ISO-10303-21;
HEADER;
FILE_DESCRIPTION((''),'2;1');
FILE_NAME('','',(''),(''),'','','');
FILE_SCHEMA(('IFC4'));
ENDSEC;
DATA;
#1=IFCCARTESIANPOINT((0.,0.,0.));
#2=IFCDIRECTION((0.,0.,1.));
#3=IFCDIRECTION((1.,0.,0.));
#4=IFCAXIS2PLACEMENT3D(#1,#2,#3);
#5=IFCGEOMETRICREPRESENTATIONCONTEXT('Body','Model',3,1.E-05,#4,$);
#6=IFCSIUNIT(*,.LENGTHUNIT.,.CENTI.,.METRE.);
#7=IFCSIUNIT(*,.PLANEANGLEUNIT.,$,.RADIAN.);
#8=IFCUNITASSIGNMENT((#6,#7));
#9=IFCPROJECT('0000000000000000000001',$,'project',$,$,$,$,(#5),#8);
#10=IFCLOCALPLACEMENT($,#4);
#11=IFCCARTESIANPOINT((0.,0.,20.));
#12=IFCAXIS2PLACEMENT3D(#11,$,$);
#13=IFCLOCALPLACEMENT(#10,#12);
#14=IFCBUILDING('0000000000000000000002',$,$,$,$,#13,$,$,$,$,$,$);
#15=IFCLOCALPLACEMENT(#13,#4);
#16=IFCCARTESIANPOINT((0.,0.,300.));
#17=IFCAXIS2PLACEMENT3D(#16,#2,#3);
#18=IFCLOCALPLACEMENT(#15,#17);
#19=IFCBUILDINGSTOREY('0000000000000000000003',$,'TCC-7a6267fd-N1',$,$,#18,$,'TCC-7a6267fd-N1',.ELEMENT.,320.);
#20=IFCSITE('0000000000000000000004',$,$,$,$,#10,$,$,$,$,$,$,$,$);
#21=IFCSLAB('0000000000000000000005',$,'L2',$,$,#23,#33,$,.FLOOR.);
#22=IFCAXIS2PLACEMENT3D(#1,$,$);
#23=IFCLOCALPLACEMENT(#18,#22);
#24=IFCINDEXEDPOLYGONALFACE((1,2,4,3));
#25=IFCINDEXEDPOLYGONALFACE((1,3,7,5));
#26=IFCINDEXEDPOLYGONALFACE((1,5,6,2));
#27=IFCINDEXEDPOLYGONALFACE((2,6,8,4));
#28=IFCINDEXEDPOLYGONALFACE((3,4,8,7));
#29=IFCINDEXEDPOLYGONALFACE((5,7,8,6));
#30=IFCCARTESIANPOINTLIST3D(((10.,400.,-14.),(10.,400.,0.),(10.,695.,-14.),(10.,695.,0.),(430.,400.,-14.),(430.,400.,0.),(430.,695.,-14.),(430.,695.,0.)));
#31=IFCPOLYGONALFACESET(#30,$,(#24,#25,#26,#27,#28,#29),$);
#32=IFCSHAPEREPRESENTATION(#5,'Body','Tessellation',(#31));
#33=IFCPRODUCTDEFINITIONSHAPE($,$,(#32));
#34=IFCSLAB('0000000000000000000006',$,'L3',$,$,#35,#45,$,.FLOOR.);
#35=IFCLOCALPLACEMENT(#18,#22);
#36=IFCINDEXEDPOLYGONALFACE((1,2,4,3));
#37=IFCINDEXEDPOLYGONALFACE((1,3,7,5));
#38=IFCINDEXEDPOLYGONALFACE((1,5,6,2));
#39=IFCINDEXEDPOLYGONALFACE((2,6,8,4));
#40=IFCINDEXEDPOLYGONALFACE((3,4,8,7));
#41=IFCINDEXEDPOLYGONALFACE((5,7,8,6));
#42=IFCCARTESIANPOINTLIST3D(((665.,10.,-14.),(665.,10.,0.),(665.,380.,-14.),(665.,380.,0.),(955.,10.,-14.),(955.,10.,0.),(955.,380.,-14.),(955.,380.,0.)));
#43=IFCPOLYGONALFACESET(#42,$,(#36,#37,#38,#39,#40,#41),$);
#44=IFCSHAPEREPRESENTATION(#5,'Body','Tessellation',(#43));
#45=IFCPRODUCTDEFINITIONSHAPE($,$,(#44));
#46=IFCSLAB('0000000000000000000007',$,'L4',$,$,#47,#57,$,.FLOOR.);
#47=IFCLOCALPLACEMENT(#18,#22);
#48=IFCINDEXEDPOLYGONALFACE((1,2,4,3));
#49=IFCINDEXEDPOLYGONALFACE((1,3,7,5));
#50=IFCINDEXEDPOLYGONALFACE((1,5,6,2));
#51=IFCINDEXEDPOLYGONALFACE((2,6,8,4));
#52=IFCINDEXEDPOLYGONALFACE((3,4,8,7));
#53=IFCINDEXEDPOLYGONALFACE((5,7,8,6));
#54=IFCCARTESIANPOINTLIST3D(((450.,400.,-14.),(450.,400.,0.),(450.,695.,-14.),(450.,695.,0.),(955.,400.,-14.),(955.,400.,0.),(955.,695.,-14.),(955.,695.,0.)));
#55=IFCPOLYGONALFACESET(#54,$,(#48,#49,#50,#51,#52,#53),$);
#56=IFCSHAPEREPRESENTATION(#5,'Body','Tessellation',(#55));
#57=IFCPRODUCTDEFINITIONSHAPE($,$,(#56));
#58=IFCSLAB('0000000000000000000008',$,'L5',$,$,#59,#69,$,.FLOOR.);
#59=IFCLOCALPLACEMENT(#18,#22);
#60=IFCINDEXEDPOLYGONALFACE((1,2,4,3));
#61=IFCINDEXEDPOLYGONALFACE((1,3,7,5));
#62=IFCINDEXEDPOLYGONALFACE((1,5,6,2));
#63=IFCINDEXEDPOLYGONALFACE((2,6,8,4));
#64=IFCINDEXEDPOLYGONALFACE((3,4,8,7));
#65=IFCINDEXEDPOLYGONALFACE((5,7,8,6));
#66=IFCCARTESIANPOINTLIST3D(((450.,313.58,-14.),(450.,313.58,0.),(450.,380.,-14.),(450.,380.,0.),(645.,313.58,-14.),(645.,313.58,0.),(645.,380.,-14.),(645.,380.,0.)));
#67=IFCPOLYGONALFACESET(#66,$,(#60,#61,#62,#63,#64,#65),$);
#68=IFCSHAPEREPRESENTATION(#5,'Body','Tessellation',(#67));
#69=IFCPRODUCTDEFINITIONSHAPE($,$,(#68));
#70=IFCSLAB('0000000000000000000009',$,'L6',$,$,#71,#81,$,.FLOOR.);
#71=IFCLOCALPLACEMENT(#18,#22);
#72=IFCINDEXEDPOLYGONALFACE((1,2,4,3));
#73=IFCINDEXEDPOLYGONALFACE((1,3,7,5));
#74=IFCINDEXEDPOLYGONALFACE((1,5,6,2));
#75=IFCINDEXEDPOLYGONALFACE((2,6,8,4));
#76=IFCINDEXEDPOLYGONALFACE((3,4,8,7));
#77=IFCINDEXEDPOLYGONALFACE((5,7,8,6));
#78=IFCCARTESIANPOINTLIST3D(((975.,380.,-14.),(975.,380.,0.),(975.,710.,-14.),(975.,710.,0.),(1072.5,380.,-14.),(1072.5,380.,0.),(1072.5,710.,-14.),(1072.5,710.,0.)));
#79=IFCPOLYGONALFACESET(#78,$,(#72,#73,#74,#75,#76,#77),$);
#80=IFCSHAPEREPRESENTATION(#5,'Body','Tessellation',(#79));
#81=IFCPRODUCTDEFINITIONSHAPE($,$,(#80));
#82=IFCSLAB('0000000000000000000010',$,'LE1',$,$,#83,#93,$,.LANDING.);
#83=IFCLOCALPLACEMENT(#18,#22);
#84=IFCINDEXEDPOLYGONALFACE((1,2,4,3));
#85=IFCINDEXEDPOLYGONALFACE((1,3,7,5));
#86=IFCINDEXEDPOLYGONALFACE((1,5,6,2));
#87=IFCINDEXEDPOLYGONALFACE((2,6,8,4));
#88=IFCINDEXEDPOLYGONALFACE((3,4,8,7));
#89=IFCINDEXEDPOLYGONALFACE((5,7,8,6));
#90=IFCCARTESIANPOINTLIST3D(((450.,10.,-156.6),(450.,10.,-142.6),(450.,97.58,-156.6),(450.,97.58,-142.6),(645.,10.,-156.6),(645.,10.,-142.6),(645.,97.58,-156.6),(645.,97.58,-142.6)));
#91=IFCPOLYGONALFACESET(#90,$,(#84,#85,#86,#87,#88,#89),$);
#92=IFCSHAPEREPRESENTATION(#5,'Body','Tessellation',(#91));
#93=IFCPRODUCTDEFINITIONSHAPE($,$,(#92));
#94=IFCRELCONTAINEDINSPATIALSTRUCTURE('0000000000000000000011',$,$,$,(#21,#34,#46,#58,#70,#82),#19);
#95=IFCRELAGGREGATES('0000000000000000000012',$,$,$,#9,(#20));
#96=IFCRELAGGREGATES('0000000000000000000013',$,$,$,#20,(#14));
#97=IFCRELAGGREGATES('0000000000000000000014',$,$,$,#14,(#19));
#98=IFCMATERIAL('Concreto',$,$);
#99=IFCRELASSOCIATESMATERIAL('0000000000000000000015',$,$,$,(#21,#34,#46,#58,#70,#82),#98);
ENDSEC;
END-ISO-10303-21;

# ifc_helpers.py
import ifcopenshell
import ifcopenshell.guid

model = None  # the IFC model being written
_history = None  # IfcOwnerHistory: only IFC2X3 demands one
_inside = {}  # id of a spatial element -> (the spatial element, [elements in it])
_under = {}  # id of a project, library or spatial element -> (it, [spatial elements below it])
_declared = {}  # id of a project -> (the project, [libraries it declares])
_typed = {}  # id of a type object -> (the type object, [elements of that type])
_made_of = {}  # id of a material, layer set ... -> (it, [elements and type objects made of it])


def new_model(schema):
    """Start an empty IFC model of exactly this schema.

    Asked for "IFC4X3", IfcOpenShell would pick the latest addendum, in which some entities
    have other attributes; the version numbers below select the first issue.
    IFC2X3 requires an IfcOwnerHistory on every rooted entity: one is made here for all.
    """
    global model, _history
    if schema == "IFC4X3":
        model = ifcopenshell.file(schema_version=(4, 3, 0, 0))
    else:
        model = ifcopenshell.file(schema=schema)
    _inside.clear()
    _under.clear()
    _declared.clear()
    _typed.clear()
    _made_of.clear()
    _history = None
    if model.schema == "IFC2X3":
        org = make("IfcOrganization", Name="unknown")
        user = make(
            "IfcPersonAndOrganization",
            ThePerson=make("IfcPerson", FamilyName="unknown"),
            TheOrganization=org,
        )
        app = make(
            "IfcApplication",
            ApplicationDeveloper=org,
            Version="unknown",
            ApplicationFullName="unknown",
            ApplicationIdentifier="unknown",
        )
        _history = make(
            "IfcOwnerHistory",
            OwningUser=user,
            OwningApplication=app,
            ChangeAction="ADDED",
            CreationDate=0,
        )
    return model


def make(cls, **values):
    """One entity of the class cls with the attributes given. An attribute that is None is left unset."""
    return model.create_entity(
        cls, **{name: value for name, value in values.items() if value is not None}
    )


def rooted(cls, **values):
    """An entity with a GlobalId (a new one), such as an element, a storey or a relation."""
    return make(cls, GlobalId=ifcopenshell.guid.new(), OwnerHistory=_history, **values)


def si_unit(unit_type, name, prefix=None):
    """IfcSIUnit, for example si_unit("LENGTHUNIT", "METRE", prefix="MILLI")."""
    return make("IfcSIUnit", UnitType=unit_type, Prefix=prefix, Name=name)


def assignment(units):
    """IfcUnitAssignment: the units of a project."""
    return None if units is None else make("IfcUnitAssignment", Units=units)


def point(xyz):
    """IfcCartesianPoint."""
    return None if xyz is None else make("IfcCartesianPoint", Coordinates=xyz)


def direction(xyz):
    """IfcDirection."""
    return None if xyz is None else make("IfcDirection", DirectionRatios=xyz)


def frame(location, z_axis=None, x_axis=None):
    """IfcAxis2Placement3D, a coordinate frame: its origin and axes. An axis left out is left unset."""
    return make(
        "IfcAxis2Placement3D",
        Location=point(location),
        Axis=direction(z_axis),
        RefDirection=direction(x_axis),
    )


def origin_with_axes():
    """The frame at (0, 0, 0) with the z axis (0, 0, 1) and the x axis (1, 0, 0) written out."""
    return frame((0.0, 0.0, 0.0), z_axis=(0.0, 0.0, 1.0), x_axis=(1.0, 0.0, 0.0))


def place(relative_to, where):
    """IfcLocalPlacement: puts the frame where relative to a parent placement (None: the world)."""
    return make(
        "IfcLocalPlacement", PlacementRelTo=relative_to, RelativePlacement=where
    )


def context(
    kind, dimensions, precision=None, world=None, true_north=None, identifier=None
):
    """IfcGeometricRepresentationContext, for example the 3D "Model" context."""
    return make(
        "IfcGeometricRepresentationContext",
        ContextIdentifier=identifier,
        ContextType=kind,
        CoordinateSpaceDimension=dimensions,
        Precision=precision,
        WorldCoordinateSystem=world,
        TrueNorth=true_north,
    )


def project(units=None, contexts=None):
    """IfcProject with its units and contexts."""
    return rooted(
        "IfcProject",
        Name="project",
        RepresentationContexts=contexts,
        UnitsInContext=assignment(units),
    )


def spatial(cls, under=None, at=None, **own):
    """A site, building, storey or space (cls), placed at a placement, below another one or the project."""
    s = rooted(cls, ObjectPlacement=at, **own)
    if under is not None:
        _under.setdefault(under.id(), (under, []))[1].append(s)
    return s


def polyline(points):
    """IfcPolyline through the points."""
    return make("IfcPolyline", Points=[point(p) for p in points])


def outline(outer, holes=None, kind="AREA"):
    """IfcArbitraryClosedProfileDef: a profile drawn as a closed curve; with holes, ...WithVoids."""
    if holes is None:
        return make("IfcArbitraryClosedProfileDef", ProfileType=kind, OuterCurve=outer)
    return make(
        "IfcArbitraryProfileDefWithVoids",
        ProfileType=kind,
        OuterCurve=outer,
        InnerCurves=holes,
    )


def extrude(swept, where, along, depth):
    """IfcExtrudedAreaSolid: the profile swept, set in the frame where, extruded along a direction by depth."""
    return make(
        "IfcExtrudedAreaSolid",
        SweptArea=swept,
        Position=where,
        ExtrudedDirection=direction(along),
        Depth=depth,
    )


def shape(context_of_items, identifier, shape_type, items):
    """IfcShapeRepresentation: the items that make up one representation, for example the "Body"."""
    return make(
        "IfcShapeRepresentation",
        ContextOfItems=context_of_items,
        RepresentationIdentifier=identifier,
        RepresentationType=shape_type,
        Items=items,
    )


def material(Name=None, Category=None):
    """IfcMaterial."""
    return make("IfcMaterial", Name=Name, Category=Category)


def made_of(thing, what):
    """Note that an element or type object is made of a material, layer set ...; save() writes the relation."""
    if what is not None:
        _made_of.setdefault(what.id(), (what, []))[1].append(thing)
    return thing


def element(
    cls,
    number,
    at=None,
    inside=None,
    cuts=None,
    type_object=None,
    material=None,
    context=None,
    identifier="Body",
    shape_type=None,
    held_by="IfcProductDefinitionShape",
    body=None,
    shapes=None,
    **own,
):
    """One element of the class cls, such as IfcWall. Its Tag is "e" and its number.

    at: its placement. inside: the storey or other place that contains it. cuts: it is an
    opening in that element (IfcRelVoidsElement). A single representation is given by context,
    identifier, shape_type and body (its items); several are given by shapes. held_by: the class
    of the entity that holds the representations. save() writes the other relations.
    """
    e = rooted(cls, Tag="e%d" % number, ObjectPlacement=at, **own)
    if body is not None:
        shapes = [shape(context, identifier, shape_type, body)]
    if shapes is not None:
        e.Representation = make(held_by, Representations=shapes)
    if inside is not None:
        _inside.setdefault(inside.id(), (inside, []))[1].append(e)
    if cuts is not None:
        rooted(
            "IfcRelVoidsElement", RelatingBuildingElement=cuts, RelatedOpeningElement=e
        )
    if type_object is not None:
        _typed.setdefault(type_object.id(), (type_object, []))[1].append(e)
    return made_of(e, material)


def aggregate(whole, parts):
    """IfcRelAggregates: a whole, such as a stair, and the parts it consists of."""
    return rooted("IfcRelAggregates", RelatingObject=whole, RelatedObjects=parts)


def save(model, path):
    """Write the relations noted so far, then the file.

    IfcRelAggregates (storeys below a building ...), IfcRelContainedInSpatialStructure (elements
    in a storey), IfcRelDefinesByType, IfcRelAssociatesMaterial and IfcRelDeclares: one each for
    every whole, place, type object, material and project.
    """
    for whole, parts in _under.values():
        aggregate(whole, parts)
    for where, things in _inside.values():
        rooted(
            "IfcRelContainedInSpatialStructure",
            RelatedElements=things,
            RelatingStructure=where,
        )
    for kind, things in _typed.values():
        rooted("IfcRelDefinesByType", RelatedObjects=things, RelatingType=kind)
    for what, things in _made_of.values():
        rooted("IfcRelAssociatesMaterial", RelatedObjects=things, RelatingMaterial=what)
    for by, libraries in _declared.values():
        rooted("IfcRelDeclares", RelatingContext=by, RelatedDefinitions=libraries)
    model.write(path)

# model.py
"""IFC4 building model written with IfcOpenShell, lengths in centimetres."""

from ifc_helpers import new_model, si_unit, frame, origin_with_axes, place, context, project, spatial, polyline, outline, extrude, material, element, save


model = new_model("IFC4")

# Units and contexts
model_context = context("Model", 3, precision=1e-05, world=origin_with_axes(), identifier="Body")
ifc_project = project(units=[si_unit("LENGTHUNIT", "METRE", prefix="CENTI"), si_unit("PLANEANGLEUNIT", "RADIAN")], contexts=[model_context])

# Site, building, storey
site_placement = place(None, origin_with_axes())
site = spatial("IfcSite", under=ifc_project, at=site_placement)
building_placement = place(site_placement, frame((0.0, 0.0, 20.0)))
building = spatial("IfcBuilding", under=site, at=building_placement)
placement = place(building_placement, origin_with_axes())
storey_placement = place(placement, frame((0.0, 0.0, 300.0), z_axis=(0.0, 0.0, 1.0), x_axis=(1.0, 0.0, 0.0)))
storey = spatial("IfcBuildingStorey", under=building, at=storey_placement, Name="TCC-7a6267fd-N1", LongName="TCC-7a6267fd-N1", CompositionType="ELEMENT", Elevation=320.0)

# Shared definitions
ifc_material = material(Name="Concreto")

# Slabs
slab_1_placement = place(storey_placement, frame((220.0, 547.5, 0.0), z_axis=(0.0, 0.0, 1.0), x_axis=(1.0, 0.0, 0.0)))
element("IfcSlab", 1, at=slab_1_placement, inside=storey, material=ifc_material, Name="L2", PredefinedType="FLOOR", context=model_context, shape_type="SolidModel", body=[
    extrude(outline(polyline([(210.0, 147.5), (-210.0, 147.5), (-210.0, -147.5), (210.0, -147.5), (210.0, 147.5), (210.0, 147.5)])), frame((0.0, 0.0, -14.0), z_axis=(0.0, 0.0, 1.0), x_axis=(1.0, 0.0, 0.0)), (0.0, 0.0, 1.0), 14.0),
])
slab_2_placement = place(storey_placement, frame((810.0, 195.0, 0.0), z_axis=(0.0, 0.0, 1.0), x_axis=(1.0, 0.0, 0.0)))
element("IfcSlab", 2, at=slab_2_placement, inside=storey, material=ifc_material, Name="L3", PredefinedType="FLOOR", context=model_context, shape_type="SolidModel", body=[
    extrude(outline(polyline([(145.0, 185.0), (-145.0, 185.0), (-145.0, -185.0), (145.0, -185.0), (145.0, 185.0), (145.0, 185.0)])), frame((0.0, 0.0, -14.0), z_axis=(0.0, 0.0, 1.0), x_axis=(1.0, 0.0, 0.0)), (0.0, 0.0, 1.0), 14.0),
])
slab_3_placement = place(storey_placement, frame((702.5, 547.5, 0.0), z_axis=(0.0, 0.0, 1.0), x_axis=(1.0, 0.0, 0.0)))
element("IfcSlab", 3, at=slab_3_placement, inside=storey, material=ifc_material, Name="L4", PredefinedType="FLOOR", context=model_context, shape_type="SolidModel", body=[
    extrude(outline(polyline([(252.5, 147.5), (-252.5, 147.5), (-252.5, -147.5), (252.5, -147.5), (252.5, 147.5), (252.5, 147.5)])), frame((0.0, 0.0, -14.0), z_axis=(0.0, 0.0, 1.0), x_axis=(1.0, 0.0, 0.0)), (0.0, 0.0, 1.0), 14.0),
])
slab_4_placement = place(storey_placement, frame((547.5, 346.79, 0.0), z_axis=(0.0, 0.0, 1.0), x_axis=(1.0, 0.0, 0.0)))
element("IfcSlab", 4, at=slab_4_placement, inside=storey, material=ifc_material, Name="L5", PredefinedType="FLOOR", context=model_context, shape_type="SolidModel", body=[
    extrude(outline(polyline([(97.5, 33.21), (-97.5, 33.21), (-97.5, -33.21), (97.5, -33.21), (97.5, 33.21), (97.5, 33.21)])), frame((0.0, 0.0, -14.0), z_axis=(0.0, 0.0, 1.0), x_axis=(1.0, 0.0, 0.0)), (0.0, 0.0, 1.0), 14.0),
])
slab_5_placement = place(storey_placement, frame((1023.75, 545.0, 0.0), z_axis=(0.0, 0.0, 1.0), x_axis=(1.0, 0.0, 0.0)))
element("IfcSlab", 5, at=slab_5_placement, inside=storey, material=ifc_material, Name="L6", PredefinedType="FLOOR", context=model_context, shape_type="SolidModel", body=[
    extrude(outline(polyline([(48.75, 165.0), (-48.75, 165.0), (-48.75, -165.0), (48.75, -165.0), (48.75, 165.0), (48.75, 165.0)])), frame((0.0, 0.0, -14.0), z_axis=(0.0, 0.0, 1.0), x_axis=(1.0, 0.0, 0.0)), (0.0, 0.0, 1.0), 14.0),
])
slab_6_placement = place(storey_placement, frame((547.5, 53.79, -142.6), z_axis=(0.0, 0.0, 1.0), x_axis=(1.0, 0.0, 0.0)))
element("IfcSlab", 6, at=slab_6_placement, inside=storey, material=ifc_material, Name="LE1", PredefinedType="LANDING", context=model_context, shape_type="SolidModel", body=[
    extrude(outline(polyline([(97.5, 43.79), (-97.5, 43.79), (-97.5, -43.79), (97.5, -43.79), (97.5, 43.79), (97.5, 43.79)])), frame((0.0, 0.0, -14.0), z_axis=(0.0, 0.0, 1.0), x_axis=(1.0, 0.0, 0.0)), (0.0, 0.0, 1.0), 14.0),
])

save(model, "model.ifc")
